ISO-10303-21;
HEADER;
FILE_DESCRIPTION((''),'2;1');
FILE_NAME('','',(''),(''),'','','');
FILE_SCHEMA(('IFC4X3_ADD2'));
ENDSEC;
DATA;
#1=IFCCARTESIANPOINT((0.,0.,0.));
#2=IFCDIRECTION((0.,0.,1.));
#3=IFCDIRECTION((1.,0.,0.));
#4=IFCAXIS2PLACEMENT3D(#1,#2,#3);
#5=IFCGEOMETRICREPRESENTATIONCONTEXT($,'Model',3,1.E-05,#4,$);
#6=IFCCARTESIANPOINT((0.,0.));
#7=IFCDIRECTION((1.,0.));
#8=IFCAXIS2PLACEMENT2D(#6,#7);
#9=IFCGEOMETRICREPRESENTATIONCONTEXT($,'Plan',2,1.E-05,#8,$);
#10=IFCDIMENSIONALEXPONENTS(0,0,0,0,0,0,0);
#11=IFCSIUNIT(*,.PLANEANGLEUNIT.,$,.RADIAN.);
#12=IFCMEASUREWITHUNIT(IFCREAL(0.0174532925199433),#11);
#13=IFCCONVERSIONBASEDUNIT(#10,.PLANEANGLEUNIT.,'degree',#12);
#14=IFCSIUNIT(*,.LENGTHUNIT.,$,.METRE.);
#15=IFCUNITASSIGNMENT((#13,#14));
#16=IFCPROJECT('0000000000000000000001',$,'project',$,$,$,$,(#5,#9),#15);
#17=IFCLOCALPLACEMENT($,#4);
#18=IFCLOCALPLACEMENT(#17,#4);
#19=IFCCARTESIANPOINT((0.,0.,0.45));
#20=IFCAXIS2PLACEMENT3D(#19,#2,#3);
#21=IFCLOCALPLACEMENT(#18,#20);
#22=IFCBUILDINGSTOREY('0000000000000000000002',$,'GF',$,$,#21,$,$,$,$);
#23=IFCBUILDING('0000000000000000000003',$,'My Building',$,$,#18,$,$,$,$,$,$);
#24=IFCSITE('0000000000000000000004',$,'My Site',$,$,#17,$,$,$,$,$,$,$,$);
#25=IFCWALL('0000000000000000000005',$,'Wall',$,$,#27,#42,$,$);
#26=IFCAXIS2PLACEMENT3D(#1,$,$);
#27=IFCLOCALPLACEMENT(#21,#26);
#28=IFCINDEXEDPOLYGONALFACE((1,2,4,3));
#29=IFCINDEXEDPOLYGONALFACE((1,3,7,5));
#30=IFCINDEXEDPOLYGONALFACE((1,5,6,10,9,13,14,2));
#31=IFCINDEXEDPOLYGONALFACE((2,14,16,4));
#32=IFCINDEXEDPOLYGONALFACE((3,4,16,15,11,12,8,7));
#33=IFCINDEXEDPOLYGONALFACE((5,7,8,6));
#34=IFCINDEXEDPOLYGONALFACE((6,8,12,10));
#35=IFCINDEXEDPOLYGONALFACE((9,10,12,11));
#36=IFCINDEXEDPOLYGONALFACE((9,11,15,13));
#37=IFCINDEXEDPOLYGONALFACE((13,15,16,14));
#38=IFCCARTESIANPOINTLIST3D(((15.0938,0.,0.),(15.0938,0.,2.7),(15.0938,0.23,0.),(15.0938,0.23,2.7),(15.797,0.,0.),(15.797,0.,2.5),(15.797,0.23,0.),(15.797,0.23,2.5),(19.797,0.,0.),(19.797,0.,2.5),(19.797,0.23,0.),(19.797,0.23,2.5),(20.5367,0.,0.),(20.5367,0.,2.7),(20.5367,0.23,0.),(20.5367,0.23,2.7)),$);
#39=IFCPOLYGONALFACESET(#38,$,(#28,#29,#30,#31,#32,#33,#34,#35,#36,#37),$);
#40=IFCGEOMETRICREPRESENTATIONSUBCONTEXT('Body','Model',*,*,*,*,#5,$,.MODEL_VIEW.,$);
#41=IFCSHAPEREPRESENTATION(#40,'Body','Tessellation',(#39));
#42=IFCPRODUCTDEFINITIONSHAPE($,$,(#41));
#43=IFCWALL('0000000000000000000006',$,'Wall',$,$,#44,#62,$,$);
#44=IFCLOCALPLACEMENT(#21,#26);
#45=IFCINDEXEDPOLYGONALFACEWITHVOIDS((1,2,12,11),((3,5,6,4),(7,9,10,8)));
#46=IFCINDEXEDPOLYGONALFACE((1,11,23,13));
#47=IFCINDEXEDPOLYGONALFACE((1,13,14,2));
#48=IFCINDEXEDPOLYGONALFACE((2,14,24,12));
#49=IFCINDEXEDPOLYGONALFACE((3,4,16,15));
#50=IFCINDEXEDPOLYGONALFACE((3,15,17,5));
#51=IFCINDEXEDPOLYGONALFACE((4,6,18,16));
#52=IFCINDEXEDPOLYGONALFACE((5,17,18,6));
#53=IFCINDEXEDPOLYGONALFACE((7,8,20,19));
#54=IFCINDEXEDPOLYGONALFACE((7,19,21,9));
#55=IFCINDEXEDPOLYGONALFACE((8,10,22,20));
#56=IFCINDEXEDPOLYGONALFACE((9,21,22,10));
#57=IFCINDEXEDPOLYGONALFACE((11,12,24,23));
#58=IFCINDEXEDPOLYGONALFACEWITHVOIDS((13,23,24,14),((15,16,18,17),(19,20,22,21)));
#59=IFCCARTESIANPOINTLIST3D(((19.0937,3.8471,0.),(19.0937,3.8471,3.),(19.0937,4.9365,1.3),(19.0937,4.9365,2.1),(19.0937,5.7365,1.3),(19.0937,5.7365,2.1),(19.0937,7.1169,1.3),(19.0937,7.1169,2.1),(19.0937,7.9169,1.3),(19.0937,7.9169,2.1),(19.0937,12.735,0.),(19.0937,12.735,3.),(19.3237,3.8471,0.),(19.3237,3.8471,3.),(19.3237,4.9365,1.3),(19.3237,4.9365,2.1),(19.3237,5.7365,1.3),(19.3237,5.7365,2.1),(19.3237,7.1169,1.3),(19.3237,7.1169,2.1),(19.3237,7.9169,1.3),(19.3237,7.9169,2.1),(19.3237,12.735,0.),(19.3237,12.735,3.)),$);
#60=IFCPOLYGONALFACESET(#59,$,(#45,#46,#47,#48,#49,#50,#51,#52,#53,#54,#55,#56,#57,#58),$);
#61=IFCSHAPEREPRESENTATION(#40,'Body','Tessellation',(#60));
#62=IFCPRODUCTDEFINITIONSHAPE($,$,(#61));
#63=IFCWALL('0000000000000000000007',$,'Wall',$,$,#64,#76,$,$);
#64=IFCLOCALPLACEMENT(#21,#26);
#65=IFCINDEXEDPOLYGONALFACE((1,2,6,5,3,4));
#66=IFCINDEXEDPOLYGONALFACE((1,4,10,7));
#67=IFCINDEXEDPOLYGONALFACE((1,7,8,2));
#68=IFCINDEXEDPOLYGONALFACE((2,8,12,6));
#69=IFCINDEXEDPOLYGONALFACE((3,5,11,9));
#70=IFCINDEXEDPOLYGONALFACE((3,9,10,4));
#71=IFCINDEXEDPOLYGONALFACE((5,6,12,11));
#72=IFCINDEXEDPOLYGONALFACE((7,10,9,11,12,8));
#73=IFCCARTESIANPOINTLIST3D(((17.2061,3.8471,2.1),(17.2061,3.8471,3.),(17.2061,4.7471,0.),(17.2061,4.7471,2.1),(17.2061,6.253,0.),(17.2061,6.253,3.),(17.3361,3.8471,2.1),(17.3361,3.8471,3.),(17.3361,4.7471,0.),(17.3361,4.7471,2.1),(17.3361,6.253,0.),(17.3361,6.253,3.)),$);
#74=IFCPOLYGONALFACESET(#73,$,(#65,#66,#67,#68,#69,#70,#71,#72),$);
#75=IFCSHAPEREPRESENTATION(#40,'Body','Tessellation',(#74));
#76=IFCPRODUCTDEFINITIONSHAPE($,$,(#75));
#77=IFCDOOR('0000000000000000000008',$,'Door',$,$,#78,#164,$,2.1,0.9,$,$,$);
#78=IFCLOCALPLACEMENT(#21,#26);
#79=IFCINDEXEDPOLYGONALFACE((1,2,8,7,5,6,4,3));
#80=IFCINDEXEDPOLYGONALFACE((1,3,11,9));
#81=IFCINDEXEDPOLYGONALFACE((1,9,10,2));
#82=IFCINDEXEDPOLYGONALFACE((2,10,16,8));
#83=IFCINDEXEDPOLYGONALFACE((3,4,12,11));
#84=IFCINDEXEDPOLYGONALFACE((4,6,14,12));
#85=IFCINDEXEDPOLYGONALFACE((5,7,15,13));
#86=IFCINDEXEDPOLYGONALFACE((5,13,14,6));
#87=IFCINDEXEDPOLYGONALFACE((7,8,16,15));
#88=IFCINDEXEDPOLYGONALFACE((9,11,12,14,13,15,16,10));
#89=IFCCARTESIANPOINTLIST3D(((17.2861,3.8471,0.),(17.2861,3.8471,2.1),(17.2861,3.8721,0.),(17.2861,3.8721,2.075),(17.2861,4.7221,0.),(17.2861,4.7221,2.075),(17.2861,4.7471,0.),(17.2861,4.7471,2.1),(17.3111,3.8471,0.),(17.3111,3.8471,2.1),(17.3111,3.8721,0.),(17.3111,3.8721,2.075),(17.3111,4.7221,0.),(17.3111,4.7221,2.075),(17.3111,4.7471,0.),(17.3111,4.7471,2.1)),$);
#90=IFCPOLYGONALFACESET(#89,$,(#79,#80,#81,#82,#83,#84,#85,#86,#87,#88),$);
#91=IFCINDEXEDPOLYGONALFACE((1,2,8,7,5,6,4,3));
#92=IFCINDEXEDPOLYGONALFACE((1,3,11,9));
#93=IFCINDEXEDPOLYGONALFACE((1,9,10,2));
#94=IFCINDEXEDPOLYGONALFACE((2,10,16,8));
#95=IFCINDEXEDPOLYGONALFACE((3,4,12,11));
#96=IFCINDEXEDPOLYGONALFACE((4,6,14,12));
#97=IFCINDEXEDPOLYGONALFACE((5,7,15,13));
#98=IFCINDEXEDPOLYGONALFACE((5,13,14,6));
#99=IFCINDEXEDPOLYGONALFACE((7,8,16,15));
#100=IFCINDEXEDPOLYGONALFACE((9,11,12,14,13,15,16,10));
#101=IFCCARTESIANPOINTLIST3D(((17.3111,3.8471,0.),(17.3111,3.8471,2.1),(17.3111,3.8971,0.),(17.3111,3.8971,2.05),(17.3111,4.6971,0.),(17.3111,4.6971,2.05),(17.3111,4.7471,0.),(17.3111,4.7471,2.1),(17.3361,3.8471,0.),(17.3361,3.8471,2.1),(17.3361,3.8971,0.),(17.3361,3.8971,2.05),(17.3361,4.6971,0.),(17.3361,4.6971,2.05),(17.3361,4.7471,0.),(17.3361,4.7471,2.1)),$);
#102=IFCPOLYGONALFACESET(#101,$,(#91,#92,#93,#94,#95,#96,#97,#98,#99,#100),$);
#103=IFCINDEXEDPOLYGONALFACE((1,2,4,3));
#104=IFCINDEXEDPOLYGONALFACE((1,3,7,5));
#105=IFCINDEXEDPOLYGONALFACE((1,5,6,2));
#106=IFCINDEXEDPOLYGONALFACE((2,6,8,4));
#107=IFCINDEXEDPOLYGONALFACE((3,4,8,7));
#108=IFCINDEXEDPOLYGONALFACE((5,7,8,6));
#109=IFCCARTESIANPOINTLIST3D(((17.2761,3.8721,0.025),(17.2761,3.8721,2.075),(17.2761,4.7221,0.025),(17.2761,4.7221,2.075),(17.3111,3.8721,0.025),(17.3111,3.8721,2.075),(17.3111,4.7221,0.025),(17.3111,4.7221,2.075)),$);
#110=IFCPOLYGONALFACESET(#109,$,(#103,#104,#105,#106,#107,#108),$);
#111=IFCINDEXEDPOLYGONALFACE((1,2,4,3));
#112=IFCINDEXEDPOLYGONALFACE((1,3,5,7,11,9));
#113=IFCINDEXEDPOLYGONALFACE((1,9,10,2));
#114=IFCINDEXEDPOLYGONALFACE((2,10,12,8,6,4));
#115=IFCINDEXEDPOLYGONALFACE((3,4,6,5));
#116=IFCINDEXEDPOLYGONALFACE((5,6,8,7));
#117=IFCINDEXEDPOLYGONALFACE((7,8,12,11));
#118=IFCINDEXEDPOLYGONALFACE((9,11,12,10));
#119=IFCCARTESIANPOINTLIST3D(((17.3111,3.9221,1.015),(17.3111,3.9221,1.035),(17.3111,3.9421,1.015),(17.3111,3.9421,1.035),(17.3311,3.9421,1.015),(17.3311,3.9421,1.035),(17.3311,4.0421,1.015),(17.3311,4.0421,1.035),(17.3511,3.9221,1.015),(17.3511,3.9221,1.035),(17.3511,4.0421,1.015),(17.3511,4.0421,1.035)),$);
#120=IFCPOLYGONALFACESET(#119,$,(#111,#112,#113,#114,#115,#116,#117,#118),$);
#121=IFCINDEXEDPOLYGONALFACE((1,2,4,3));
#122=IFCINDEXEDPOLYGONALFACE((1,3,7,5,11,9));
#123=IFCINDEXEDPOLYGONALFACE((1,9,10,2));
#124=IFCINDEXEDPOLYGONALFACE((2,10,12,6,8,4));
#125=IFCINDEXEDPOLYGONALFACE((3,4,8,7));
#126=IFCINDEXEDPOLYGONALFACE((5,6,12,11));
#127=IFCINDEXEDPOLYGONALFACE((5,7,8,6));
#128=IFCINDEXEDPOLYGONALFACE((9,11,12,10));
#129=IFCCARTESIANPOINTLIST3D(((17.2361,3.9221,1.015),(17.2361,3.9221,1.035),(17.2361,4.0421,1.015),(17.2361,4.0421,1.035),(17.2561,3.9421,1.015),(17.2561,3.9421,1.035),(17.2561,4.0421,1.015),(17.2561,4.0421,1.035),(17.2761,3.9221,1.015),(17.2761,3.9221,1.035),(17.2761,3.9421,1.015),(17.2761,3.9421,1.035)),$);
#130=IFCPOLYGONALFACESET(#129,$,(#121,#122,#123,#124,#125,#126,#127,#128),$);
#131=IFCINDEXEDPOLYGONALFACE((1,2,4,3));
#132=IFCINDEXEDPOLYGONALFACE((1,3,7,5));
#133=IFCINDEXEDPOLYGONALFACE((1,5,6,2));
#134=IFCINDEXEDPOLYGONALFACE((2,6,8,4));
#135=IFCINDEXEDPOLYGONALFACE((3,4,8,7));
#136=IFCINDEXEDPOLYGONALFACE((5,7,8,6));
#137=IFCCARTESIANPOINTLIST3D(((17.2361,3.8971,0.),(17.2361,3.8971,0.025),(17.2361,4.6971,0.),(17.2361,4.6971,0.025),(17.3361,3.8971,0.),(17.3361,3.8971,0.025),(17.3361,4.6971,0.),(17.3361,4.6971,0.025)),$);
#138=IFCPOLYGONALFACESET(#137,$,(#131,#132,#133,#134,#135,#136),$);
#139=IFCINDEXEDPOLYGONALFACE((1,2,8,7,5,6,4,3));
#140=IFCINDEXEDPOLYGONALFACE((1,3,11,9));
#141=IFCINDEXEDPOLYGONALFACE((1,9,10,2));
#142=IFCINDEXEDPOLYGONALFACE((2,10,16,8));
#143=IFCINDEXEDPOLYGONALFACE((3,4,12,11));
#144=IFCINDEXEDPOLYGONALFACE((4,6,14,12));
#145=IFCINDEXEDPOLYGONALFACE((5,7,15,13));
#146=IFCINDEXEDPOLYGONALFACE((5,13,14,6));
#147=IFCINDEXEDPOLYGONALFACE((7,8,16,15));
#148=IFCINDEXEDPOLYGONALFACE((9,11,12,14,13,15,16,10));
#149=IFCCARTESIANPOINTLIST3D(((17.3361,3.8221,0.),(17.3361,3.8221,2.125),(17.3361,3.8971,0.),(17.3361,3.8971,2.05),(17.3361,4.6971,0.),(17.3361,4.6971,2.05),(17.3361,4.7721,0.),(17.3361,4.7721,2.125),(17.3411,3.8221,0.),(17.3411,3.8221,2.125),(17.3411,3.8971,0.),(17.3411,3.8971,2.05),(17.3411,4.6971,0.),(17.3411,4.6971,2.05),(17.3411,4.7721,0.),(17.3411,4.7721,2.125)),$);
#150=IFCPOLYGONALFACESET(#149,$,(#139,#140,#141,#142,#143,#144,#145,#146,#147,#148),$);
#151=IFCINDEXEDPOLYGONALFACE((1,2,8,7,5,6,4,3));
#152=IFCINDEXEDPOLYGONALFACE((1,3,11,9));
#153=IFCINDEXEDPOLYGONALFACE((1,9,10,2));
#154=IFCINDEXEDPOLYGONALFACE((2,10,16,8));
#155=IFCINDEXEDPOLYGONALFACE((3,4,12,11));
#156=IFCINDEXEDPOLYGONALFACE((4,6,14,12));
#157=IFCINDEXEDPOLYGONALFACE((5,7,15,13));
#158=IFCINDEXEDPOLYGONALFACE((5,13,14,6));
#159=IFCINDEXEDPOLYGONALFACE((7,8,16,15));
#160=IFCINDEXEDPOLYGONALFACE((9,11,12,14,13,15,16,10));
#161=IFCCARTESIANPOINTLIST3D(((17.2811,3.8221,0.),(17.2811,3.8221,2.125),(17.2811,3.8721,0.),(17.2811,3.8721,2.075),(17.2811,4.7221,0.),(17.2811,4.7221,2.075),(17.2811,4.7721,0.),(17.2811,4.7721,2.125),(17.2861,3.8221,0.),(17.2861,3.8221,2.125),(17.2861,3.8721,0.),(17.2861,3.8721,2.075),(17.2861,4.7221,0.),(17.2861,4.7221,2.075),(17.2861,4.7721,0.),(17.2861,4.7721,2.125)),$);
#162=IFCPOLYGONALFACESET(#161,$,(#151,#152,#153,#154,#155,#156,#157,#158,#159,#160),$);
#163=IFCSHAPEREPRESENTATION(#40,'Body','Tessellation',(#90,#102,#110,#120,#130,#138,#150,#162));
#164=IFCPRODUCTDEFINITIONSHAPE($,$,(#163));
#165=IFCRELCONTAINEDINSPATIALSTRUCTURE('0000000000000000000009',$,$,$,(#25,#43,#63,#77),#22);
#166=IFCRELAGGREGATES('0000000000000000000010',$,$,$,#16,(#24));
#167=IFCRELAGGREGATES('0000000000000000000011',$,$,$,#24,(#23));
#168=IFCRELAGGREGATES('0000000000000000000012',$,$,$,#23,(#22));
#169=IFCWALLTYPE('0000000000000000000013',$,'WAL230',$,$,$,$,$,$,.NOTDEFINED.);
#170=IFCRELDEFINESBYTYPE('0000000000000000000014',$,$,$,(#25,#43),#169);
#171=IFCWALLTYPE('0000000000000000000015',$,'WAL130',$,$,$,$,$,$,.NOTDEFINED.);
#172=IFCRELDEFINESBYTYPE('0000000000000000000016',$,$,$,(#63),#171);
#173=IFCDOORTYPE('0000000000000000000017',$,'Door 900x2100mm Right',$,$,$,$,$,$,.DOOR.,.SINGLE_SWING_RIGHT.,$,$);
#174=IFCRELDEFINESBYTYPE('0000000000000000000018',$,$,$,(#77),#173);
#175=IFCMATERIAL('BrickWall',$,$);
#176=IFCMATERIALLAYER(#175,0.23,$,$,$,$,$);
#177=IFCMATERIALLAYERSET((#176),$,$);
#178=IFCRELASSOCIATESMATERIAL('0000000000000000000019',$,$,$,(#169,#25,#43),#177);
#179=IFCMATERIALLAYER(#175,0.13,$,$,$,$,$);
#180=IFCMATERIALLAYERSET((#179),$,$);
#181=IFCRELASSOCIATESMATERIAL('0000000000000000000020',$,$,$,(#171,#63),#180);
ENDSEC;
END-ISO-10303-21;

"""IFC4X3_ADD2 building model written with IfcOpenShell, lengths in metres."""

from ifc_helpers import new_model, entity, si_unit, converted_unit, frame, origin_with_axes, origin_2d_with_axis, place, context, subcontext, project, spatial, line, indexed_curve, outline, extrude, shape, source, transform, mapped, material, layer, layer_set, layer_usage, type_object, type_shapes, element, fill, save


model = new_model("IFC4X3_ADD2")

# Units and contexts
model_context = context("Model", 3, precision=1e-05, world=origin_with_axes())
plan_context = context("Plan", 2, precision=1e-05, world=origin_2d_with_axis())
body_context_1 = subcontext(model_context, "Body", "Model", "MODEL_VIEW")
body_context_2 = subcontext(plan_context, "Body", "Plan", "PLAN_VIEW")
ifc_project = project(units=[converted_unit("PLANEANGLEUNIT", "degree", entity("IfcReal", 0.0174532925199433), si_unit("PLANEANGLEUNIT", "RADIAN"), dimensions=[0, 0, 0, 0, 0, 0, 0]), si_unit("LENGTHUNIT", "METRE")], contexts=[model_context, plan_context])

# Site, building, storey
site_placement = place(None, origin_with_axes())
site = spatial("IfcSite", under=ifc_project, at=site_placement, Name="My Site")
building_placement = place(site_placement, origin_with_axes())
building = spatial("IfcBuilding", under=site, at=building_placement, Name="My Building")
storey_placement = place(building_placement, frame((0.0, 0.0, 0.45), z_axis=(0.0, 0.0, 1.0), x_axis=(1.0, 0.0, 0.0)))
storey = spatial("IfcBuildingStorey", under=building, at=storey_placement, Name="GF")

# Wall, opening
ifc_material = material(Name="BrickWall")
ifc_layer_1 = layer(ifc_material, 0.23)
ifc_layer_set_1 = layer_set([ifc_layer_1])
ifc_layer_usage_1 = layer_usage(ifc_layer_set_1, "AXIS2", "POSITIVE", 0.0)
wall_type_1 = type_object("IfcWallType", Name="WAL230", PredefinedType="NOTDEFINED", material=ifc_layer_set_1)
wall_1_placement = place(storey_placement, frame((20.5367, 0.23, 0.0), z_axis=(0.0, 0.0, 1.0), x_axis=(-1.0, 0.0, 0.0)))
wall_1 = element("IfcWall", 1, at=wall_1_placement, inside=storey, type_object=wall_type_1, material=ifc_layer_usage_1, Name="Wall", context=body_context_1, shape_type="SweptSolid", body=[
    extrude(outline(indexed_curve([(0.0, 0.0), (0.0, 0.23), (5.4429, 0.23), (5.4429, 0.0), (0.0, 0.0)], self_intersect=False)), origin_with_axes(), (0.0, 0.0, 1.0), 2.7),
])
shared_shape_1 = source(origin_with_axes(), body_context_1, "Body", "SweptSolid", [
    extrude(outline(indexed_curve([(0.0, 0.0), (4.0, 0.0), (4.0, 2.5), (0.0, 2.5)], segments=[line(1, 2, 3, 4, 1)])), frame((0.0, -0.6, 0.0), z_axis=(0.0, -1.0, 0.0), x_axis=(1.0, 0.0, 0.0)), (0.0, 0.0, -1.0), 1.2),
])
opening_1_placement = place(wall_1_placement, frame((0.7398, 0.0, 0.0), z_axis=(0.0, 0.0, 1.0), x_axis=(1.0, 0.0, 0.0)))
element("IfcOpeningElement", 2, at=opening_1_placement, cuts=wall_1, PredefinedType="OPENING", context=body_context_1, shape_type="MappedRepresentation", body=[
    mapped(shared_shape_1, transform((0.0, 0.0, 0.0), x_axis=(1.0, 0.0, 0.0), y_axis=(0.0, 1.0, 0.0), z_axis=(0.0, 0.0, 1.0), scale=1.0)),
])

# Wall, openings
ifc_layer_usage_2 = layer_usage(ifc_layer_set_1, "AXIS2", "POSITIVE", 0.0)
wall_2_placement = place(storey_placement, frame((19.3237, 3.8471, 0.0), z_axis=(0.0, 0.0, 1.0), x_axis=(0.0, 1.0, 0.0)))
wall_2 = element("IfcWall", 3, at=wall_2_placement, inside=storey, type_object=wall_type_1, material=ifc_layer_usage_2, Name="Wall", context=body_context_1, shape_type="SweptSolid", body=[
    extrude(outline(indexed_curve([(0.0, 0.0), (0.0, 0.23), (8.8879, 0.23), (8.8879, 0.0), (0.0, 0.0)], self_intersect=False)), origin_with_axes(), (0.0, 0.0, 1.0), 3.0),
])
shared_shape_2 = source(origin_with_axes(), body_context_1, "Body", "SweptSolid", [
    extrude(outline(indexed_curve([(0.0, 0.0), (0.8, 0.0), (0.8, 0.8), (0.0, 0.8)], segments=[line(1, 2, 3, 4, 1)])), frame((-0.4, -0.6, 0.0), z_axis=(0.0, -1.0, 0.0), x_axis=(1.0, 0.0, 0.0)), (0.0, 0.0, -1.0), 1.2),
])
opening_2_placement = place(wall_2_placement, frame((1.4894, 0.0, 1.3), z_axis=(0.0, 0.0, 1.0), x_axis=(1.0, 0.0, 0.0)))
element("IfcOpeningElement", 4, at=opening_2_placement, cuts=wall_2, PredefinedType="OPENING", context=body_context_1, shape_type="MappedRepresentation", body=[
    mapped(shared_shape_2, transform((0.0, 0.0, 0.0), x_axis=(1.0, 0.0, 0.0), y_axis=(0.0, 1.0, 0.0), z_axis=(0.0, 0.0, 1.0), scale=1.0)),
])
opening_3_placement = place(wall_2_placement, frame((3.6698, 0.0, 1.3), z_axis=(0.0, 0.0, 1.0), x_axis=(1.0, 0.0, 0.0)))
element("IfcOpeningElement", 5, at=opening_3_placement, cuts=wall_2, PredefinedType="OPENING", context=body_context_1, shape_type="MappedRepresentation", body=[
    mapped(shared_shape_2, transform((0.0, 0.0, 0.0), x_axis=(1.0, 0.0, 0.0), y_axis=(0.0, 1.0, 0.0), z_axis=(0.0, 0.0, 1.0), scale=1.0)),
])

# Wall, opening, door
ifc_layer_2 = layer(ifc_material, 0.13)
ifc_layer_set_2 = layer_set([ifc_layer_2])
ifc_layer_usage_3 = layer_usage(ifc_layer_set_2, "AXIS2", "POSITIVE", 0.0)
wall_type_2 = type_object("IfcWallType", Name="WAL130", PredefinedType="NOTDEFINED", material=ifc_layer_set_2)
wall_3_placement = place(storey_placement, frame((17.3361, 3.8471, 0.0), z_axis=(0.0, 0.0, 1.0), x_axis=(0.0, 1.0, 0.0)))
wall_3 = element("IfcWall", 6, at=wall_3_placement, inside=storey, type_object=wall_type_2, material=ifc_layer_usage_3, Name="Wall", context=body_context_1, shape_type="SweptSolid", body=[
    extrude(outline(indexed_curve([(0.0, 0.0), (0.0, 0.13), (2.4059, 0.13), (2.4059, 0.0), (0.0, 0.0)], self_intersect=False)), origin_with_axes(), (0.0, 0.0, 1.0), 3.0),
])
shared_shape_3 = source(origin_with_axes(), body_context_1, "Body", "SweptSolid", [
    extrude(outline(indexed_curve([(0.0, 0.0), (0.9, 0.0), (0.9, 2.1), (0.0, 2.1)], segments=[line(1, 2, 3, 4, 1)])), frame((0.0, -0.6, 0.0), z_axis=(0.0, -1.0, 0.0), x_axis=(1.0, 0.0, 0.0)), (0.0, 0.0, -1.0), 1.2),
])
opening_4_placement = place(wall_3_placement, origin_with_axes())
opening_4 = element("IfcOpeningElement", 7, at=opening_4_placement, cuts=wall_3, PredefinedType="OPENING", context=body_context_1, shape_type="MappedRepresentation", body=[
    mapped(shared_shape_3, transform((0.0, 0.0, 0.0), x_axis=(1.0, 0.0, 0.0), y_axis=(0.0, 1.0, 0.0), z_axis=(0.0, 0.0, 1.0), scale=1.0)),
])
door_type = type_object("IfcDoorType", Name="Door 900x2100mm Right", OperationType="SINGLE_SWING_RIGHT", PredefinedType="DOOR")
shared_shape_4 = source(origin_with_axes(), body_context_1, "Body", "SweptSolid", [
    extrude(outline(indexed_curve([(0.0, 0.0), (0.0, 2.1), (0.9, 2.1), (0.9, 0.0), (0.875, 0.0), (0.875, 2.075), (0.025, 2.075), (0.025, 0.0)], segments=[line(1, 2, 3, 4, 5, 6, 7, 8, 1)])), frame((0.0, 0.025, 0.0), z_axis=(0.0, -1.0, 0.0), x_axis=(1.0, 0.0, 0.0)), (0.0, 0.0, -1.0), 0.025),
    extrude(outline(indexed_curve([(0.0, 0.0), (0.0, 2.1), (0.9, 2.1), (0.9, 0.0), (0.85, 0.0), (0.85, 2.05), (0.05, 2.05), (0.05, 0.0)], segments=[line(1, 2, 3, 4, 5, 6, 7, 8, 1)])), frame((0.0, 0.0, 0.0), z_axis=(0.0, -1.0, 0.0), x_axis=(1.0, 0.0, 0.0)), (0.0, 0.0, -1.0), 0.025),
    extrude(outline(indexed_curve([(0.0, 0.0), (0.85, 0.0), (0.85, 0.035), (0.0, 0.035)], segments=[line(1, 2, 3, 4, 1)])), frame((0.025, 0.025, 0.025), z_axis=(0.0, 0.0, 1.0), x_axis=(1.0, 0.0, 0.0)), (0.0, 0.0, 1.0), 2.05),
    extrude(outline(indexed_curve([(0.0, 0.0), (0.0, -0.04), (0.12, -0.04), (0.12, -0.02), (0.02, -0.02), (0.02, 0.0)], segments=[line(1, 2, 3, 4, 5, 6, 1)])), frame((0.075, 0.025, 1.015), z_axis=(0.0, 0.0, 1.0), x_axis=(1.0, 0.0, 0.0)), (0.0, 0.0, 1.0), 0.02),
    extrude(outline(indexed_curve([(0.0, 0.0), (0.0, 0.04), (0.12, 0.04), (0.12, 0.02), (0.02, 0.02), (0.02, 0.0)], segments=[line(1, 2, 3, 4, 5, 6, 1)])), frame((0.075, 0.06, 1.015), z_axis=(0.0, 0.0, 1.0), x_axis=(1.0, 0.0, 0.0)), (0.0, 0.0, 1.0), 0.02),
    extrude(outline(indexed_curve([(0.0, 0.0), (0.8, 0.0), (0.8, 0.1), (0.0, 0.1)], segments=[line(1, 2, 3, 4, 1)])), frame((0.05, 0.0, 0.0), z_axis=(0.0, 0.0, 1.0), x_axis=(1.0, 0.0, 0.0)), (0.0, 0.0, 1.0), 0.025),
    extrude(outline(indexed_curve([(0.0, 0.0), (0.0, 2.125), (0.95, 2.125), (0.95, 0.0), (0.875, 0.0), (0.875, 2.05), (0.075, 2.05), (0.075, 0.0)], segments=[line(1, 2, 3, 4, 5, 6, 7, 8, 1)])), frame((-0.025, -0.005, 0.0), z_axis=(0.0, -1.0, 0.0), x_axis=(1.0, 0.0, 0.0)), (0.0, 0.0, -1.0), 0.005),
    extrude(outline(indexed_curve([(0.0, 0.0), (0.0, 2.125), (0.95, 2.125), (0.95, 0.0), (0.9, 0.0), (0.9, 2.075), (0.05, 2.075), (0.05, 0.0)], segments=[line(1, 2, 3, 4, 5, 6, 7, 8, 1)])), frame((-0.025, 0.05, 0.0), z_axis=(0.0, -1.0, 0.0), x_axis=(1.0, 0.0, 0.0)), (0.0, 0.0, -1.0), 0.005),
])
shared_shape_5 = source(origin_with_axes(), body_context_2, "Body", "Curve2D", [
    entity("IfcIndexedPolyCurve", entity("IfcCartesianPointList2D", [[0.0, 0.0], [0.0, 0.05], [0.025, 0.05], [0.025, 0.025], [0.05, 0.025], [0.05, 0.0]]), [entity("IfcLineIndex", [1, 2, 3, 4, 5, 6, 1])]),
    entity("IfcIndexedPolyCurve", entity("IfcCartesianPointList2D", [[0.9, 0.0], [0.9, 0.05], [0.875, 0.05], [0.875, 0.025], [0.85, 0.025], [0.85, 0.0]]), [entity("IfcLineIndex", [1, 2, 3, 4, 5, 6, 1])]),
    entity("IfcTrimmedCurve", entity("IfcEllipse", entity("IfcAxis2Placement2D", entity("IfcCartesianPoint", [0.84, 0.05]), entity("IfcDirection", [1.0, 0.0])), 0.815, 0.85), [entity("IfcCartesianPoint", [0.84, 0.9])], [entity("IfcCartesianPoint", [0.025, 0.05])], True, "CARTESIAN"),
    entity("IfcIndexedPolyCurve", entity("IfcCartesianPointList2D", [[0.875, 0.05], [0.84, 0.05], [0.84, 0.9], [0.875, 0.9]]), [entity("IfcLineIndex", [1, 2, 3, 4, 1])]),
])
type_shapes(door_type, [shared_shape_4, shared_shape_5])
door_placement = place(opening_4_placement, origin_with_axes())
door = element("IfcDoor", 8, at=door_placement, inside=storey, type_object=door_type, Name="Door", OverallHeight=2.1, OverallWidth=0.9, shapes=[
    shape(body_context_1, "Body", "MappedRepresentation", [mapped(shared_shape_4, transform((0.0, 0.0, 0.0), x_axis=(1.0, 0.0, 0.0), y_axis=(0.0, 1.0, 0.0), z_axis=(0.0, 0.0, 1.0), scale=1.0))]),
    shape(body_context_2, "Body", "MappedRepresentation", [mapped(shared_shape_5, transform((0.0, 0.0, 0.0), x_axis=(1.0, 0.0, 0.0), y_axis=(0.0, 1.0, 0.0), z_axis=(0.0, 0.0, 1.0), scale=1.0))]),
])
fill(opening_4, door)

save(model, "model.ifc")
